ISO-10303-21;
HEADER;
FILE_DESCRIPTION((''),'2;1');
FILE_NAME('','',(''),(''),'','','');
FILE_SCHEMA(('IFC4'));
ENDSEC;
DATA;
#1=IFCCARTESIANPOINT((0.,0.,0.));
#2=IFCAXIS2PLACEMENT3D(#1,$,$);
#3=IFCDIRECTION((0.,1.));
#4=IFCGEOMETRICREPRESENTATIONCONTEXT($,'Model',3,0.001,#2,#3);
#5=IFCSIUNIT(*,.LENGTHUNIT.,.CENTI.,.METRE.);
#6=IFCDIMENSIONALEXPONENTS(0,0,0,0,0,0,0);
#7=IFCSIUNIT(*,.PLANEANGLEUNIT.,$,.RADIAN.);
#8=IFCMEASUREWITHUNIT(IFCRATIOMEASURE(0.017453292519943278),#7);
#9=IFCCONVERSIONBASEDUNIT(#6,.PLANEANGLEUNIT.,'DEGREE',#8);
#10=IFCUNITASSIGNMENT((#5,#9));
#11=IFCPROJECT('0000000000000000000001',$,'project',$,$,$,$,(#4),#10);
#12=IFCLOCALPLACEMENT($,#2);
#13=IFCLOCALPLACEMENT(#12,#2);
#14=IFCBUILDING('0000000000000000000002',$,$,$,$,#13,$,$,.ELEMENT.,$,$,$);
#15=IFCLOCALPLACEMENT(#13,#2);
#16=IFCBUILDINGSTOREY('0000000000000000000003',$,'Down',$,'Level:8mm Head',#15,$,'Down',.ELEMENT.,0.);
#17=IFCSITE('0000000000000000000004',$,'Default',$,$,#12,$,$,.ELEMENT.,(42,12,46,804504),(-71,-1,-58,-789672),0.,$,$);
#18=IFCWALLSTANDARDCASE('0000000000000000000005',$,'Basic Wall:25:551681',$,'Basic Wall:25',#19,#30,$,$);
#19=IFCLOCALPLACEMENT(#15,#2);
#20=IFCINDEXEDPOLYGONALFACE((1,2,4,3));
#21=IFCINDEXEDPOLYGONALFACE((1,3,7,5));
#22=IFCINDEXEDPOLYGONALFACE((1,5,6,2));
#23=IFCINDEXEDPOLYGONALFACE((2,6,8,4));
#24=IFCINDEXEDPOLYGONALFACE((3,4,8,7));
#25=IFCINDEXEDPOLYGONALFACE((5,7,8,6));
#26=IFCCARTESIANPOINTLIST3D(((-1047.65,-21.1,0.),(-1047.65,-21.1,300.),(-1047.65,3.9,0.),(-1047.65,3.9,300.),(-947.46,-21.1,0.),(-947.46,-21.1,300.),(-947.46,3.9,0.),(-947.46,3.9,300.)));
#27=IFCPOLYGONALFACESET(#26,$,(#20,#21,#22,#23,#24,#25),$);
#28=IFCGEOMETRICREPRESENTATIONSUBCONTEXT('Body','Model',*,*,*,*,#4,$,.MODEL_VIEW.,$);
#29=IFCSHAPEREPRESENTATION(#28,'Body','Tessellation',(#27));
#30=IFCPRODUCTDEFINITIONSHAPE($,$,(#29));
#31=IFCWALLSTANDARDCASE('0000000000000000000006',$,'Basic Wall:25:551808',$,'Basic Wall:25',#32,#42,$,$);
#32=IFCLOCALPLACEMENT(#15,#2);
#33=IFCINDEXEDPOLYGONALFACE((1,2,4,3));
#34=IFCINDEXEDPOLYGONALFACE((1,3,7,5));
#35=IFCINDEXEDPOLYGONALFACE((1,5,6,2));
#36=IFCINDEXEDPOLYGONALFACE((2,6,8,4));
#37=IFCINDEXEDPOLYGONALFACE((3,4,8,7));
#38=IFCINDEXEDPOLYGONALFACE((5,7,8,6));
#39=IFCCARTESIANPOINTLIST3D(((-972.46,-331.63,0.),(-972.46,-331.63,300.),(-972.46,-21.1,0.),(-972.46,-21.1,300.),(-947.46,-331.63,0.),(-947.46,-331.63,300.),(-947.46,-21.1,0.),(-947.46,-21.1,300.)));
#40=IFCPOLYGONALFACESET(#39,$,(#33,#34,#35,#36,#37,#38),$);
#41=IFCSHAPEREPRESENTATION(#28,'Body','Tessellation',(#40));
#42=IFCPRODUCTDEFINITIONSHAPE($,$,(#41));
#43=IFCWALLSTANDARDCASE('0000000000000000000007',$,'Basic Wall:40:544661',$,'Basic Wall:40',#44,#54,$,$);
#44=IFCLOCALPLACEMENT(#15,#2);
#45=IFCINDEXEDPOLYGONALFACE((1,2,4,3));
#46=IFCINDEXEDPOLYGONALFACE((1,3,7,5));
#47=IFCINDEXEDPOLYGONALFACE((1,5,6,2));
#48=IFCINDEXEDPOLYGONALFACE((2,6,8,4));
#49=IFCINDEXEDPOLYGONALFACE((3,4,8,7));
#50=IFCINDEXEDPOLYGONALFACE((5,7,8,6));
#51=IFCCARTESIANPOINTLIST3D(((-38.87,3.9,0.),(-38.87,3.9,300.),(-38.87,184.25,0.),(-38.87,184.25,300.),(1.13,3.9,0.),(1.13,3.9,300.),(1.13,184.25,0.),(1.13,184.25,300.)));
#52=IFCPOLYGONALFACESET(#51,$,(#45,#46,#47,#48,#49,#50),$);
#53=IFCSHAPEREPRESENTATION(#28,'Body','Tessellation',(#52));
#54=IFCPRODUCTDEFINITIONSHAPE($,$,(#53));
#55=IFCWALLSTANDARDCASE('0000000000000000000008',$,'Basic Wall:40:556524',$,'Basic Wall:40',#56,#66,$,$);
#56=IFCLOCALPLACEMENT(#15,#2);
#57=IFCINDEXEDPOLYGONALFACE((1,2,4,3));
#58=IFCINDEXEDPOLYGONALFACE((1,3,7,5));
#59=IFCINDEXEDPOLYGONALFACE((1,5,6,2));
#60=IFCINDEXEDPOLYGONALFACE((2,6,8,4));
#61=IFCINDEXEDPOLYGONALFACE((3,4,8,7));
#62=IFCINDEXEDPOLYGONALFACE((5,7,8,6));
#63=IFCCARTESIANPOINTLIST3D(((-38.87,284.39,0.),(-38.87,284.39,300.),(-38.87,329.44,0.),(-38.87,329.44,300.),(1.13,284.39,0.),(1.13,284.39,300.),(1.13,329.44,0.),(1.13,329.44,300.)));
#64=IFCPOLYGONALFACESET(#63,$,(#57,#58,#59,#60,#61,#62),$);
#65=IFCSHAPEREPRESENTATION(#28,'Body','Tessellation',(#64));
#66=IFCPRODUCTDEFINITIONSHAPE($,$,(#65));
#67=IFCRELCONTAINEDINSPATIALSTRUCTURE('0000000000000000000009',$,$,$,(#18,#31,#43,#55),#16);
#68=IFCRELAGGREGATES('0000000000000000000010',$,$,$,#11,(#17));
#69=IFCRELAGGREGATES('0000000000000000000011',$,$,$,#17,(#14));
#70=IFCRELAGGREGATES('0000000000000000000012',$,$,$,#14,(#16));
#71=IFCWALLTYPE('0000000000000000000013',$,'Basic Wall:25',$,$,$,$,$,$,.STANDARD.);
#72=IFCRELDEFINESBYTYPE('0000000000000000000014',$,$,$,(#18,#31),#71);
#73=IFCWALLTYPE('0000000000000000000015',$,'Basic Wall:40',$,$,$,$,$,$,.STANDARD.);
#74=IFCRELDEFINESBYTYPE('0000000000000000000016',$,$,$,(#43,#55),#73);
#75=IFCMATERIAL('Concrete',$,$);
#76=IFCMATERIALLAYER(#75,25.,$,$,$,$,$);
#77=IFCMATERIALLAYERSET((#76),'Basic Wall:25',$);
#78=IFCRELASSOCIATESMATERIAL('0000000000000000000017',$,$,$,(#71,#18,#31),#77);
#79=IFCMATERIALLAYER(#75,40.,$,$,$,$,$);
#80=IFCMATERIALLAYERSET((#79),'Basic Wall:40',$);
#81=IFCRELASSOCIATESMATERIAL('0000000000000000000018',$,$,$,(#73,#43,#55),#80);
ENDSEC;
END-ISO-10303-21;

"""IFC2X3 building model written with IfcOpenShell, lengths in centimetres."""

from ifc_helpers import new_model, entity, si_unit, converted_unit, direction, frame, frame_2d, origin, place, context, subcontext, project, spatial, rectangle, extrude, material, layer, layer_set, layer_usage, type_object, element, save


model = new_model("IFC2X3")

# Units and contexts
model_context = context("Model", 3, precision=0.001, world=origin(), true_north=direction((0.0, 1.0)))
body_context = subcontext(model_context, "Body", "Model", "MODEL_VIEW")
ifc_project = project(units=[si_unit("LENGTHUNIT", "METRE", prefix="CENTI"), converted_unit("PLANEANGLEUNIT", "DEGREE", entity("IfcRatioMeasure", 0.017453292519943278), si_unit("PLANEANGLEUNIT", "RADIAN"), dimensions=[0, 0, 0, 0, 0, 0, 0])], contexts=[model_context])

# Site, building, storey
site_placement = place(None, origin())
site = spatial("IfcSite", under=ifc_project, at=site_placement, Name="Default", CompositionType="ELEMENT", RefLatitude=(42, 12, 46, 804504), RefLongitude=(-71, -1, -58, -789672), RefElevation=0.0)
building_placement = place(site_placement, origin())
building = spatial("IfcBuilding", under=site, at=building_placement, CompositionType="ELEMENT")
storey_placement = place(building_placement, origin())
storey = spatial("IfcBuildingStorey", under=building, at=storey_placement, Name="Down", ObjectType="Level:8mm Head", LongName="Down", CompositionType="ELEMENT", Elevation=0.0)

# Walls
ifc_material = material(Name="Concrete")
ifc_layer_1 = layer(ifc_material, 25.0)
ifc_layer_set_1 = layer_set([ifc_layer_1], Name="Basic Wall:25")
wall_type_1 = type_object("IfcWallType", Name="Basic Wall:25", PredefinedType="STANDARD", material=ifc_layer_set_1)
ifc_layer_usage_1 = layer_usage(ifc_layer_set_1, "AXIS2", "POSITIVE", -12.5)
wall_1_placement = place(storey_placement, frame((-1047.65, -8.6, 0.0)))
element("IfcWallStandardCase", 1, at=wall_1_placement, inside=storey, type_object=wall_type_1, material=ifc_layer_usage_1, Name="Basic Wall:25:551681", ObjectType="Basic Wall:25", context=body_context, shape_type="SweptSolid", body=[
    extrude(rectangle(XDim=100.2, YDim=25.0, at=frame_2d((50.1, 0.0), x_axis=(-1.0, 0.0))), origin(), (0.0, 0.0, 1.0), 300.0),
])
ifc_layer_usage_2 = layer_usage(ifc_layer_set_1, "AXIS2", "NEGATIVE", 12.5)
wall_2_placement = place(storey_placement, frame((-959.96, -21.1, 0.0), z_axis=(0.0, 0.0, 1.0), x_axis=(0.0, -1.0, 0.0)))
element("IfcWallStandardCase", 2, at=wall_2_placement, inside=storey, type_object=wall_type_1, material=ifc_layer_usage_2, Name="Basic Wall:25:551808", ObjectType="Basic Wall:25", context=body_context, shape_type="SweptSolid", body=[
    extrude(rectangle(XDim=310.54, YDim=25.0, at=frame_2d((155.27, 0.0), x_axis=(-1.0, 0.0))), origin(), (0.0, 0.0, 1.0), 300.0),
])
ifc_layer_2 = layer(ifc_material, 40.0)
ifc_layer_set_2 = layer_set([ifc_layer_2], Name="Basic Wall:40")
ifc_layer_usage_3 = layer_usage(ifc_layer_set_2, "AXIS2", "POSITIVE", -20.0)
wall_type_2 = type_object("IfcWallType", Name="Basic Wall:40", PredefinedType="STANDARD", material=ifc_layer_set_2)
wall_3_placement = place(storey_placement, frame((-18.87, 3.9, 0.0), z_axis=(0.0, 0.0, 1.0), x_axis=(0.0, 1.0, 0.0)))
element("IfcWallStandardCase", 3, at=wall_3_placement, inside=storey, type_object=wall_type_2, material=ifc_layer_usage_3, Name="Basic Wall:40:544661", ObjectType="Basic Wall:40", context=body_context, shape_type="SweptSolid", body=[
    extrude(rectangle(XDim=180.34, YDim=40.0, at=frame_2d((90.17, 0.0), x_axis=(-1.0, 0.0))), origin(), (0.0, 0.0, 1.0), 300.0),
])
ifc_layer_usage_4 = layer_usage(ifc_layer_set_2, "AXIS2", "POSITIVE", -20.0)
wall_4_placement = place(storey_placement, frame((-18.87, 284.39, 0.0), z_axis=(0.0, 0.0, 1.0), x_axis=(0.0, 1.0, 0.0)))
element("IfcWallStandardCase", 4, at=wall_4_placement, inside=storey, type_object=wall_type_2, material=ifc_layer_usage_4, Name="Basic Wall:40:556524", ObjectType="Basic Wall:40", context=body_context, shape_type="SweptSolid", body=[
    extrude(rectangle(XDim=45.05, YDim=40.0, at=frame_2d((22.52, 0.0), x_axis=(-1.0, 0.0))), origin(), (0.0, 0.0, 1.0), 300.0),
])

save(model, "model.ifc")
